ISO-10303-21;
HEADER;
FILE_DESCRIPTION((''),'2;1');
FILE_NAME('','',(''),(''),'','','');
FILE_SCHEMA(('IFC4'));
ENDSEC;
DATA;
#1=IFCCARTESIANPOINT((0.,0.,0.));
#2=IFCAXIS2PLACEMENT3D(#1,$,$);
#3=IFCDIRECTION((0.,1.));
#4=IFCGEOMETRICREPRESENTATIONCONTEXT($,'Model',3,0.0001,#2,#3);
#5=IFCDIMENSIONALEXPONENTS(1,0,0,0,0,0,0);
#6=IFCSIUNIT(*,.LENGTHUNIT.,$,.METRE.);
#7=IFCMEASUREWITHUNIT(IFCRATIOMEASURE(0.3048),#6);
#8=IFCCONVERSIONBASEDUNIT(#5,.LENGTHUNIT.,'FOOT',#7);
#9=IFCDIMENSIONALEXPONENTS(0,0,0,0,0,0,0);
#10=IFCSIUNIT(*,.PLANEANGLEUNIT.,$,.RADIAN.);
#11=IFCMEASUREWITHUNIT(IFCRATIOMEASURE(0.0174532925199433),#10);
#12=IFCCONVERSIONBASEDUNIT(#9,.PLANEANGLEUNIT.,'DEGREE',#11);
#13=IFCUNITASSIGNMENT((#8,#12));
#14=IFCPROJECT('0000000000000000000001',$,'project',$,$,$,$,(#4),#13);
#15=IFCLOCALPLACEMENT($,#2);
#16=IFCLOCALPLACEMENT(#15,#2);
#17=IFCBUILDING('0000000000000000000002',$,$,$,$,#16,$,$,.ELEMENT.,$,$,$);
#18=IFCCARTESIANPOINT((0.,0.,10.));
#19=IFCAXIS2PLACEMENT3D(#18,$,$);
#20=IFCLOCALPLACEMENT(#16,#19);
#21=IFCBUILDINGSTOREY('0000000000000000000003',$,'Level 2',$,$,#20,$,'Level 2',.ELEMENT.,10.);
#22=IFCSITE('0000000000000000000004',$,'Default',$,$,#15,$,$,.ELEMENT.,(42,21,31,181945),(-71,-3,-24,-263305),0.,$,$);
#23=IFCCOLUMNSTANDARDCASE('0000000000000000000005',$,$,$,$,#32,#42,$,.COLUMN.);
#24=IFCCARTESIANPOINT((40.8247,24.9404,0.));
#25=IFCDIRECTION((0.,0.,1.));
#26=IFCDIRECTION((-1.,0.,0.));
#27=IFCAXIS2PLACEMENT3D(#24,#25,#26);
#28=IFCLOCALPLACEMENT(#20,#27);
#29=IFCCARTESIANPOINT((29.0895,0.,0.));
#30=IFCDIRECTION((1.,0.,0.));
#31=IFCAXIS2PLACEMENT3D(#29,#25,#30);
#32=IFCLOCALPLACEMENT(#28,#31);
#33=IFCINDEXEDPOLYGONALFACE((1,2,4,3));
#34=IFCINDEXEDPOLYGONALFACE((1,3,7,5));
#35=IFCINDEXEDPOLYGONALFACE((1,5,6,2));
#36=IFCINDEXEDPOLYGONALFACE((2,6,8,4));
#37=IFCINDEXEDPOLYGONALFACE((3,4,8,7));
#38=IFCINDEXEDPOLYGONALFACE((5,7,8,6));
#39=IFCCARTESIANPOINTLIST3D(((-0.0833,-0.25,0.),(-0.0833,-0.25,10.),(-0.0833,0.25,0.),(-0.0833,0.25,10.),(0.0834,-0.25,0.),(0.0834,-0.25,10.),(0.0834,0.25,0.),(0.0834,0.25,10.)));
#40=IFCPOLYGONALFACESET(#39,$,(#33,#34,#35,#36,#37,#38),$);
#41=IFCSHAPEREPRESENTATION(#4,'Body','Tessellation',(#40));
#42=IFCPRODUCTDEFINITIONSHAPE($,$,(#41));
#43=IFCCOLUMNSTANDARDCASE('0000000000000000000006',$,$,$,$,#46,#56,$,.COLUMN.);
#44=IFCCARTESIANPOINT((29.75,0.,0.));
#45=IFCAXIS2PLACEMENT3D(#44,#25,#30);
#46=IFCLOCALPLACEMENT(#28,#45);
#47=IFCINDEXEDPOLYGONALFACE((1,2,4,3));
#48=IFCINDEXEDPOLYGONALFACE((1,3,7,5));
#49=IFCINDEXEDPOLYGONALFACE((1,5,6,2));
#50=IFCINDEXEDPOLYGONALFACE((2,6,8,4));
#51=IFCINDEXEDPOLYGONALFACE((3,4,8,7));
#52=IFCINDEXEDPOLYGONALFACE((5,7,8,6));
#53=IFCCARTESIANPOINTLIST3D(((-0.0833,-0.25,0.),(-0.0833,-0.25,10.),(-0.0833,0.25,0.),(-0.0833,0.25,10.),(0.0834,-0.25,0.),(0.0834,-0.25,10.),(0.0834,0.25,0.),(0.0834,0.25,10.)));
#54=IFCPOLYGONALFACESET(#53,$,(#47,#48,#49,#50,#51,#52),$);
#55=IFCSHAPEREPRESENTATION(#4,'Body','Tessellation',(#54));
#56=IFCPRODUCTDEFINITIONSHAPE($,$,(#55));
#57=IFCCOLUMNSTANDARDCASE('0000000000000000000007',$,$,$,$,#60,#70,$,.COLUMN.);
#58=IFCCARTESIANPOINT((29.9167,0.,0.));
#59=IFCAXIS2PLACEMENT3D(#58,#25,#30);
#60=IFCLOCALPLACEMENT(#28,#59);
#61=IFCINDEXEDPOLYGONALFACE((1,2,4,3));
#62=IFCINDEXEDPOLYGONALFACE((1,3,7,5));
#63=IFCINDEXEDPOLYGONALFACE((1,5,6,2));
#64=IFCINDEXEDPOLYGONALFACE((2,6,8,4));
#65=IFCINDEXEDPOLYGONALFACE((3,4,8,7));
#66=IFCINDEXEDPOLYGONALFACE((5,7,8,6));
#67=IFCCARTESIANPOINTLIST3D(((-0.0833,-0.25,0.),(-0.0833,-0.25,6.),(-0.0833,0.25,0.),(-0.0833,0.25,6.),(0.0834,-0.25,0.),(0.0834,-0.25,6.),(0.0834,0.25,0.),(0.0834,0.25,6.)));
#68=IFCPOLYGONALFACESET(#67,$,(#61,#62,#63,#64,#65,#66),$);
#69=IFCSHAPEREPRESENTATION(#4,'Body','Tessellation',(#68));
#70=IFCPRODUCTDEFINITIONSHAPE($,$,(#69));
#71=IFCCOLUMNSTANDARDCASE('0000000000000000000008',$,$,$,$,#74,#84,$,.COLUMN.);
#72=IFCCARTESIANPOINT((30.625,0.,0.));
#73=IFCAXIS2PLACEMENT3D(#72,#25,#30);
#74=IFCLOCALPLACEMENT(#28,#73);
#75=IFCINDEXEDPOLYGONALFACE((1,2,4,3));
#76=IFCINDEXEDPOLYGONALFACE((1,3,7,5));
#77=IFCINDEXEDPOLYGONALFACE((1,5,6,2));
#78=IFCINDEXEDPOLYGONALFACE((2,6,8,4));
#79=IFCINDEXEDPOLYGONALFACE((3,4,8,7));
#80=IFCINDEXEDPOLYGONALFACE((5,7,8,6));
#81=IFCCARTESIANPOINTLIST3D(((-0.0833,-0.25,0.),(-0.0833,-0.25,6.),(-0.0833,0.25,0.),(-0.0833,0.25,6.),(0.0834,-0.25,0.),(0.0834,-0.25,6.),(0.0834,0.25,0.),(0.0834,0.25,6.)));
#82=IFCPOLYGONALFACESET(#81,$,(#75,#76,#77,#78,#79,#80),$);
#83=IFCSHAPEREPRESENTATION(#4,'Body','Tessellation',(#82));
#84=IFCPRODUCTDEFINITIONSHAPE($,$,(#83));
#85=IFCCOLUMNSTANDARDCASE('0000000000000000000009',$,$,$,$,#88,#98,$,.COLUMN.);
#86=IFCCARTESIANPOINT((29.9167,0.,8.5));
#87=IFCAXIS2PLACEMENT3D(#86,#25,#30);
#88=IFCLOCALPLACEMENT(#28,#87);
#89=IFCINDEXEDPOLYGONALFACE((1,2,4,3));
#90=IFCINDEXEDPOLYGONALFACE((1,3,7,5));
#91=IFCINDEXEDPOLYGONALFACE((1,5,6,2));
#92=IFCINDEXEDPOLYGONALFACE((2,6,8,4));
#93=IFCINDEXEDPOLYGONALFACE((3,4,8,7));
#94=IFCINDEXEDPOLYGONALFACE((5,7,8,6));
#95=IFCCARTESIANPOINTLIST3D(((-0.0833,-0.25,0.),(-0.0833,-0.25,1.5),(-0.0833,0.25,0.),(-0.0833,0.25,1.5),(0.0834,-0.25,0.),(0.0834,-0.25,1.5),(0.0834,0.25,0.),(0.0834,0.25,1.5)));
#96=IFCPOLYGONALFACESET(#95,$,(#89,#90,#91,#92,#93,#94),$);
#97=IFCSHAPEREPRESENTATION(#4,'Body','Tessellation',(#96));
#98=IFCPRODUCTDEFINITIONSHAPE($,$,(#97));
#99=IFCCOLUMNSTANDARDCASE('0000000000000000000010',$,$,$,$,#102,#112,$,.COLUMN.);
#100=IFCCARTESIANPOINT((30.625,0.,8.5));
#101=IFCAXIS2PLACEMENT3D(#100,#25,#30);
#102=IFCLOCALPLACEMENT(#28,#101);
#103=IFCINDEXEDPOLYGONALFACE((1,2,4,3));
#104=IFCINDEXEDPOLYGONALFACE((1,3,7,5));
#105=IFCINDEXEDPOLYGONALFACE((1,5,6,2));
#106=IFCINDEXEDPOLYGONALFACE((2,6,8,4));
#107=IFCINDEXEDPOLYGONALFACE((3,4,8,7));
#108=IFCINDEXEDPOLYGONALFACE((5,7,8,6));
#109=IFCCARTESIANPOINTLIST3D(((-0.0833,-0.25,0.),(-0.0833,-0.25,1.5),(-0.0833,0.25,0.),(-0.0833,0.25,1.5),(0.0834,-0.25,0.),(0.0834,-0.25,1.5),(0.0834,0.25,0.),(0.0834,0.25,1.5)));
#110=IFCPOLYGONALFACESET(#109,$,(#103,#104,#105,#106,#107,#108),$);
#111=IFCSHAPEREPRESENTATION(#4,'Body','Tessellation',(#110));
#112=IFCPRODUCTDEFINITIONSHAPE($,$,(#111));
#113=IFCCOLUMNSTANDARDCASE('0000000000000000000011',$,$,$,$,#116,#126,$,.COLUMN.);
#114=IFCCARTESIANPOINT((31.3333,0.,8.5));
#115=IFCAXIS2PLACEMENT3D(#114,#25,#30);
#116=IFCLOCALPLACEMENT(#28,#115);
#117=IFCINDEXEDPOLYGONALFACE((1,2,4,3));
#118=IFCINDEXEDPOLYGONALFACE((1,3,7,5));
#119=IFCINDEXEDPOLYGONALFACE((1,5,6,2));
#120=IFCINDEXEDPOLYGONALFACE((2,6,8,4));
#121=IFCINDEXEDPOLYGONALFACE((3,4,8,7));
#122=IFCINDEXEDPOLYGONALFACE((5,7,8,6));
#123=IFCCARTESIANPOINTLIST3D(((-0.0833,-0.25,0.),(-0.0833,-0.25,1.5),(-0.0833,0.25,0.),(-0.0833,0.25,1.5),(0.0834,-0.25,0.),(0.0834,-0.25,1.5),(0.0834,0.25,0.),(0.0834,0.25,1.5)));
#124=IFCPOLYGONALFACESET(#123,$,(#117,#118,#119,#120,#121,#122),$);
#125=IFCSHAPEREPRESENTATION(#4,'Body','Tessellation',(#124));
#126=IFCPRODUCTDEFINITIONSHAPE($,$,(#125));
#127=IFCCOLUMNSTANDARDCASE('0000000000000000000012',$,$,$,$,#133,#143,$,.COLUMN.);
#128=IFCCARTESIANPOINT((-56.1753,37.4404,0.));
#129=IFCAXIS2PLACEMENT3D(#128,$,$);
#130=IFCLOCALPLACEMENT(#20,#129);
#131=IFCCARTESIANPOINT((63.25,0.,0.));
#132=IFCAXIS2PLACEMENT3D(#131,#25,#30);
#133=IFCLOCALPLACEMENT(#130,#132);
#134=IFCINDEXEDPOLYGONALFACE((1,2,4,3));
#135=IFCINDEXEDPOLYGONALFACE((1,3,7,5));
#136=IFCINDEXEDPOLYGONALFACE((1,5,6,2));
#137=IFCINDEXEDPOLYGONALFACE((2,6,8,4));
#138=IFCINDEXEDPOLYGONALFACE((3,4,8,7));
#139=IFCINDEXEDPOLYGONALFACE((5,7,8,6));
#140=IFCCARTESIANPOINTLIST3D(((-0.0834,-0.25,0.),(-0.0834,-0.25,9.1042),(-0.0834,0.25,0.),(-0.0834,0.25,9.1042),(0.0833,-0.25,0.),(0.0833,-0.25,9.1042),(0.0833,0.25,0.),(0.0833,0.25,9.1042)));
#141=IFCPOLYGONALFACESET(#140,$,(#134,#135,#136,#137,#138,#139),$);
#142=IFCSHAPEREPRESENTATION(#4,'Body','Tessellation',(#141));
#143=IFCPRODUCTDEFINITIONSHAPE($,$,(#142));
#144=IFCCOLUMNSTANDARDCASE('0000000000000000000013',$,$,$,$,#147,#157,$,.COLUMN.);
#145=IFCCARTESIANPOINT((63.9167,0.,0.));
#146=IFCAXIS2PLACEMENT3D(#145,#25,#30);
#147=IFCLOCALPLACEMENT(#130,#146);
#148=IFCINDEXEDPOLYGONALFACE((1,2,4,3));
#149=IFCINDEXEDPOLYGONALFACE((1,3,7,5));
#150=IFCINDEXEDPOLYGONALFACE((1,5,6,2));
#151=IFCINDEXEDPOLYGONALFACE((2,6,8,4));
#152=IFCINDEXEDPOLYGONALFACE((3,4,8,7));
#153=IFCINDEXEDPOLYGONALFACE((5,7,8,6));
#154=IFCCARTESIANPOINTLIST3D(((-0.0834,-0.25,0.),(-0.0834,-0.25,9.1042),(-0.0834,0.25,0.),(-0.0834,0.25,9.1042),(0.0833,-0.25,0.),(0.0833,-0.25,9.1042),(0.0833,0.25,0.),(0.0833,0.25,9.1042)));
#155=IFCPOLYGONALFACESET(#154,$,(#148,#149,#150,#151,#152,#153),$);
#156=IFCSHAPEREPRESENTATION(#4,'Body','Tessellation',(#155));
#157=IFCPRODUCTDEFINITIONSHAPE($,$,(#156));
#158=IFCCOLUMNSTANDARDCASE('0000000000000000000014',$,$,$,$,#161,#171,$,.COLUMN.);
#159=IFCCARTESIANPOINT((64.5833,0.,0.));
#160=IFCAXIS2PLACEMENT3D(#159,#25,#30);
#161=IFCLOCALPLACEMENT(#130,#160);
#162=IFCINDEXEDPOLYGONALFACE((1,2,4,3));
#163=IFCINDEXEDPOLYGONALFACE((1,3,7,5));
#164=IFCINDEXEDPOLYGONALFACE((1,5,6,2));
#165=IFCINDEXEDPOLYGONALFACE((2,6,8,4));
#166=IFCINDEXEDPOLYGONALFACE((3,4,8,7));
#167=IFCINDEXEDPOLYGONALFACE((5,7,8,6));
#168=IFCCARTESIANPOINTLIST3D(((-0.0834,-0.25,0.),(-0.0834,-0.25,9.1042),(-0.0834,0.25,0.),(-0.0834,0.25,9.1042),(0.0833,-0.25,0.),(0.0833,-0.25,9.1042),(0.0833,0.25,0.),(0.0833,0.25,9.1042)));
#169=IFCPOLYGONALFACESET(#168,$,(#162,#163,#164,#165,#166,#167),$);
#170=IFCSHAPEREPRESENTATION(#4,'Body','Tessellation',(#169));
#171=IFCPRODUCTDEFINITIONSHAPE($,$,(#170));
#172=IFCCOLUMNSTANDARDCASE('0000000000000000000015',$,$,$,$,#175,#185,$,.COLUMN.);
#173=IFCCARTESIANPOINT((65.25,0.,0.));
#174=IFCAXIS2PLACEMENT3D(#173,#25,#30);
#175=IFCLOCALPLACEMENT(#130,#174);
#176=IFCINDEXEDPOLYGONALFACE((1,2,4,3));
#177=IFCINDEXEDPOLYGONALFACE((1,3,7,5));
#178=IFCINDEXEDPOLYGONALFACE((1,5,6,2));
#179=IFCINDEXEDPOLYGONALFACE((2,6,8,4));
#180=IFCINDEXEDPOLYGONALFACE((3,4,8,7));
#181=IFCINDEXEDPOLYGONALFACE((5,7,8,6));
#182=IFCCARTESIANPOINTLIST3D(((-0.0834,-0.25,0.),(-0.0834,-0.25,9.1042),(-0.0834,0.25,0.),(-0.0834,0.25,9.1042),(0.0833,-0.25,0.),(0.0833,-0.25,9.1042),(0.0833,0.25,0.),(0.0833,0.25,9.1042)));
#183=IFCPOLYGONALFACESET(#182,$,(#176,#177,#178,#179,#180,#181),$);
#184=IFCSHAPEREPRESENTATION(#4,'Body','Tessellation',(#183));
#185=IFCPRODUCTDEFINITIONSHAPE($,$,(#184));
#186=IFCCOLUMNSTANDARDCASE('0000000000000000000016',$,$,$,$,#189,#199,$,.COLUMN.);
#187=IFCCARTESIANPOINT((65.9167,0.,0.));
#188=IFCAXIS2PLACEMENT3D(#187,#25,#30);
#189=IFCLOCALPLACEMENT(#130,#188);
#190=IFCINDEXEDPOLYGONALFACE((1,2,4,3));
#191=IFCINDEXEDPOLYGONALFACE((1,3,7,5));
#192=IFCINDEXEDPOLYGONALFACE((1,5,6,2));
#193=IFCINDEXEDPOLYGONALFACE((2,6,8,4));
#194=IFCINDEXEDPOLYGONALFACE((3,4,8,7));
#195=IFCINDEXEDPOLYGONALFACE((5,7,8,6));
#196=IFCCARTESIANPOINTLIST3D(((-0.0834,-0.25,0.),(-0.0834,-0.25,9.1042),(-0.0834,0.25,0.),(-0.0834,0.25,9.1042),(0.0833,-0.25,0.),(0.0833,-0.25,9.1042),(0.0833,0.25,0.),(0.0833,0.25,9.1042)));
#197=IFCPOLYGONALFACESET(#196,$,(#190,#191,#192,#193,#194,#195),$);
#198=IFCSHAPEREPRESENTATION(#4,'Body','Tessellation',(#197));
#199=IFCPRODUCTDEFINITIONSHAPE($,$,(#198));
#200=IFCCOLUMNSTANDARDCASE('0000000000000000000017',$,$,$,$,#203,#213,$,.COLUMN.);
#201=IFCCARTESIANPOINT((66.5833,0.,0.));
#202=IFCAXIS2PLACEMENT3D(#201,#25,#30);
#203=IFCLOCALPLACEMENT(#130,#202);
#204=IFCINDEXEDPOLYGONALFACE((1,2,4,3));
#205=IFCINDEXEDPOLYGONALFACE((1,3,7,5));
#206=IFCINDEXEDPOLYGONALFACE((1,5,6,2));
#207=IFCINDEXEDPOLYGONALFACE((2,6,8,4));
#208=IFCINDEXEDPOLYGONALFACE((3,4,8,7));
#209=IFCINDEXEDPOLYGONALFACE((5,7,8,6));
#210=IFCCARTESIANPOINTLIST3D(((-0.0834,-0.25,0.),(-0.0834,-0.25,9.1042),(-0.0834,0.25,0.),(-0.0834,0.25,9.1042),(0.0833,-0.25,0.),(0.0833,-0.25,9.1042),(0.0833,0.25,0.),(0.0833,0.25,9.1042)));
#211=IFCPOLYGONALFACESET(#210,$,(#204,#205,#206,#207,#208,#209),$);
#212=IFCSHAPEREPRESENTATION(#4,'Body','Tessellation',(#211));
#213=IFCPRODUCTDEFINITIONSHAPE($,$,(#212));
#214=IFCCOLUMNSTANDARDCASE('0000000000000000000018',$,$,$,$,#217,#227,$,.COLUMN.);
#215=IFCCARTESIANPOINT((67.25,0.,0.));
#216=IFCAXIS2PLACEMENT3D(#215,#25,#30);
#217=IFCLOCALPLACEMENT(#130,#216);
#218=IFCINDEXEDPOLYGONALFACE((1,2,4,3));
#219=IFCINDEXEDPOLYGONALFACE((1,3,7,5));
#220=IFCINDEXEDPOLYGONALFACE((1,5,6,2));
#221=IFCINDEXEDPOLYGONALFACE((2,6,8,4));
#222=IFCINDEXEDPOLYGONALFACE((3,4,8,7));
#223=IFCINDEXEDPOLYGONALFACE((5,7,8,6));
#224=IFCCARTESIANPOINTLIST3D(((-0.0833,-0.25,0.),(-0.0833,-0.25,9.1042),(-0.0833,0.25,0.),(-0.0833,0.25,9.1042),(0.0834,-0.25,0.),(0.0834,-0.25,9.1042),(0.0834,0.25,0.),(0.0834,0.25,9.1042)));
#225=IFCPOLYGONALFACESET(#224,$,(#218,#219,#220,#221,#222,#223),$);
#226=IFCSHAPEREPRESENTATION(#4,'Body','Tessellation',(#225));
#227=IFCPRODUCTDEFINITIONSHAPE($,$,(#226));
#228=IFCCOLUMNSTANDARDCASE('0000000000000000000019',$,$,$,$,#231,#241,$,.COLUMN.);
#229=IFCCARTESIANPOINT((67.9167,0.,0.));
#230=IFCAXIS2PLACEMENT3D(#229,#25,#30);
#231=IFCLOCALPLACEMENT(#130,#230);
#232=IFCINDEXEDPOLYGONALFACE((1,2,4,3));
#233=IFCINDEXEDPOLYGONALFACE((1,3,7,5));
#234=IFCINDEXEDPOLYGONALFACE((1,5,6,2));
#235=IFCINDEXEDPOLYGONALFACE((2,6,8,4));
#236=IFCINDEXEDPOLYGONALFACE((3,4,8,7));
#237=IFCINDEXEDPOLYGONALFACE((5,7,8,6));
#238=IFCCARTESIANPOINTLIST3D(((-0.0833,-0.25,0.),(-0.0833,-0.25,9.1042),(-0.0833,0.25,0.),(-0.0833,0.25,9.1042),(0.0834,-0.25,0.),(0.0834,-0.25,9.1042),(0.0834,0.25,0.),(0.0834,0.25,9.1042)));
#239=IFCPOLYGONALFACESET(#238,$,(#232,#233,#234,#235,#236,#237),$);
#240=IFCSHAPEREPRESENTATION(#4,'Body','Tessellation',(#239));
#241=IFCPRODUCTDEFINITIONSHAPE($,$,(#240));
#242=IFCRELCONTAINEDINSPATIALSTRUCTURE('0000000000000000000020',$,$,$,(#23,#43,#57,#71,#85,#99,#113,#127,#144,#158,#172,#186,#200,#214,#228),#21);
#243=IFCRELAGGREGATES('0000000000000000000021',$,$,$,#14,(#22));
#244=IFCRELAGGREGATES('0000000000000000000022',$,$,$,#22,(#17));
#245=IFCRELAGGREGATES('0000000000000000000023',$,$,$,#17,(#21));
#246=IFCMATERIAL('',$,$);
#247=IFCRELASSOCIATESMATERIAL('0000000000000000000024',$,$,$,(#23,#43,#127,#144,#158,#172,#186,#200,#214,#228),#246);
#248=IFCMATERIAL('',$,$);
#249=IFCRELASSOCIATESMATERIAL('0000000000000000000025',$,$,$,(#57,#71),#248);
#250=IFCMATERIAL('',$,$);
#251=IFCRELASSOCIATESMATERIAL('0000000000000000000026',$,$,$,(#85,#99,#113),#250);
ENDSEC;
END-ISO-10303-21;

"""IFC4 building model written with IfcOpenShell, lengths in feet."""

from ifc_helpers import new_model, entity, si_unit, converted_unit, direction, frame, origin, place, context, project, spatial, rectangle, extrude, material, element, save


model = new_model("IFC4")

# Units and contexts
model_context = context("Model", 3, precision=0.0001, world=origin(), true_north=direction((0.0, 1.0)))
ifc_project = project(units=[converted_unit("LENGTHUNIT", "FOOT", entity("IfcRatioMeasure", 0.3048), si_unit("LENGTHUNIT", "METRE"), dimensions=[1, 0, 0, 0, 0, 0, 0]), converted_unit("PLANEANGLEUNIT", "DEGREE", entity("IfcRatioMeasure", 0.0174532925199433), si_unit("PLANEANGLEUNIT", "RADIAN"), dimensions=[0, 0, 0, 0, 0, 0, 0])], contexts=[model_context])

# Site, building, storey
site_placement = place(None, origin())
site = spatial("IfcSite", under=ifc_project, at=site_placement, Name="Default", CompositionType="ELEMENT", RefLatitude=(42, 21, 31, 181945), RefLongitude=(-71, -3, -24, -263305), RefElevation=0.0)
building_placement = place(site_placement, origin())
building = spatial("IfcBuilding", under=site, at=building_placement, CompositionType="ELEMENT")
storey_placement = place(building_placement, frame((0.0, 0.0, 10.0)))
storey = spatial("IfcBuildingStorey", under=building, at=storey_placement, Name="Level 2", LongName="Level 2", CompositionType="ELEMENT", Elevation=10.0)

# Columns
ifc_material_1 = material(Name="")
placement_1 = place(storey_placement, frame((40.8247, 24.9404, 0.0), z_axis=(0.0, 0.0, 1.0), x_axis=(-1.0, 0.0, 0.0)))
for number, where, z_axis, x_axis in (
    (1, (29.0895, 0.0, 0.0), (0.0, 0.0, 1.0), (1.0, 0.0, 0.0)),
    (2, (29.75, 0.0, 0.0), (0.0, 0.0, 1.0), (1.0, 0.0, 0.0)),
):
    element("IfcColumnStandardCase", number, at=place(placement_1, frame(where, z_axis=z_axis, x_axis=x_axis)), inside=storey, material=ifc_material_1, PredefinedType="COLUMN", context=model_context, shape_type="SweptSolid", body=[
        extrude(rectangle(XDim=0.1667, YDim=0.5), origin(), (0.0, 0.0, 1.0), 10.0),
    ])
ifc_material_2 = material(Name="")
for number, where, z_axis, x_axis in (
    (3, (29.9167, 0.0, 0.0), (0.0, 0.0, 1.0), (1.0, 0.0, 0.0)),
    (4, (30.625, 0.0, 0.0), (0.0, 0.0, 1.0), (1.0, 0.0, 0.0)),
):
    element("IfcColumnStandardCase", number, at=place(placement_1, frame(where, z_axis=z_axis, x_axis=x_axis)), inside=storey, material=ifc_material_2, PredefinedType="COLUMN", context=model_context, shape_type="SweptSolid", body=[
        extrude(rectangle(XDim=0.1667, YDim=0.5), origin(), (0.0, 0.0, 1.0), 6.0),
    ])
ifc_material_3 = material(Name="")
for number, where, z_axis, x_axis in (
    (5, (29.9167, 0.0, 8.5), (0.0, 0.0, 1.0), (1.0, 0.0, 0.0)),
    (6, (30.625, 0.0, 8.5), (0.0, 0.0, 1.0), (1.0, 0.0, 0.0)),
    (7, (31.3333, 0.0, 8.5), (0.0, 0.0, 1.0), (1.0, 0.0, 0.0)),
):
    element("IfcColumnStandardCase", number, at=place(placement_1, frame(where, z_axis=z_axis, x_axis=x_axis)), inside=storey, material=ifc_material_3, PredefinedType="COLUMN", context=model_context, shape_type="SweptSolid", body=[
        extrude(rectangle(XDim=0.1667, YDim=0.5), origin(), (0.0, 0.0, 1.0), 1.5),
    ])
placement_2 = place(storey_placement, frame((-56.1753, 37.4404, 0.0)))
for number, where, z_axis, x_axis in (
    (8, (63.25, 0.0, 0.0), (0.0, 0.0, 1.0), (1.0, 0.0, 0.0)),
    (9, (63.9167, 0.0, 0.0), (0.0, 0.0, 1.0), (1.0, 0.0, 0.0)),
    (10, (64.5833, 0.0, 0.0), (0.0, 0.0, 1.0), (1.0, 0.0, 0.0)),
    (11, (65.25, 0.0, 0.0), (0.0, 0.0, 1.0), (1.0, 0.0, 0.0)),
    (12, (65.9167, 0.0, 0.0), (0.0, 0.0, 1.0), (1.0, 0.0, 0.0)),
    (13, (66.5833, 0.0, 0.0), (0.0, 0.0, 1.0), (1.0, 0.0, 0.0)),
    (14, (67.25, 0.0, 0.0), (0.0, 0.0, 1.0), (1.0, 0.0, 0.0)),
    (15, (67.9167, 0.0, 0.0), (0.0, 0.0, 1.0), (1.0, 0.0, 0.0)),
):
    element("IfcColumnStandardCase", number, at=place(placement_2, frame(where, z_axis=z_axis, x_axis=x_axis)), inside=storey, material=ifc_material_1, PredefinedType="COLUMN", context=model_context, shape_type="SweptSolid", body=[
        extrude(rectangle(XDim=0.1667, YDim=0.5), origin(), (0.0, 0.0, 1.0), 9.1042),
    ])

save(model, "model.ifc")
